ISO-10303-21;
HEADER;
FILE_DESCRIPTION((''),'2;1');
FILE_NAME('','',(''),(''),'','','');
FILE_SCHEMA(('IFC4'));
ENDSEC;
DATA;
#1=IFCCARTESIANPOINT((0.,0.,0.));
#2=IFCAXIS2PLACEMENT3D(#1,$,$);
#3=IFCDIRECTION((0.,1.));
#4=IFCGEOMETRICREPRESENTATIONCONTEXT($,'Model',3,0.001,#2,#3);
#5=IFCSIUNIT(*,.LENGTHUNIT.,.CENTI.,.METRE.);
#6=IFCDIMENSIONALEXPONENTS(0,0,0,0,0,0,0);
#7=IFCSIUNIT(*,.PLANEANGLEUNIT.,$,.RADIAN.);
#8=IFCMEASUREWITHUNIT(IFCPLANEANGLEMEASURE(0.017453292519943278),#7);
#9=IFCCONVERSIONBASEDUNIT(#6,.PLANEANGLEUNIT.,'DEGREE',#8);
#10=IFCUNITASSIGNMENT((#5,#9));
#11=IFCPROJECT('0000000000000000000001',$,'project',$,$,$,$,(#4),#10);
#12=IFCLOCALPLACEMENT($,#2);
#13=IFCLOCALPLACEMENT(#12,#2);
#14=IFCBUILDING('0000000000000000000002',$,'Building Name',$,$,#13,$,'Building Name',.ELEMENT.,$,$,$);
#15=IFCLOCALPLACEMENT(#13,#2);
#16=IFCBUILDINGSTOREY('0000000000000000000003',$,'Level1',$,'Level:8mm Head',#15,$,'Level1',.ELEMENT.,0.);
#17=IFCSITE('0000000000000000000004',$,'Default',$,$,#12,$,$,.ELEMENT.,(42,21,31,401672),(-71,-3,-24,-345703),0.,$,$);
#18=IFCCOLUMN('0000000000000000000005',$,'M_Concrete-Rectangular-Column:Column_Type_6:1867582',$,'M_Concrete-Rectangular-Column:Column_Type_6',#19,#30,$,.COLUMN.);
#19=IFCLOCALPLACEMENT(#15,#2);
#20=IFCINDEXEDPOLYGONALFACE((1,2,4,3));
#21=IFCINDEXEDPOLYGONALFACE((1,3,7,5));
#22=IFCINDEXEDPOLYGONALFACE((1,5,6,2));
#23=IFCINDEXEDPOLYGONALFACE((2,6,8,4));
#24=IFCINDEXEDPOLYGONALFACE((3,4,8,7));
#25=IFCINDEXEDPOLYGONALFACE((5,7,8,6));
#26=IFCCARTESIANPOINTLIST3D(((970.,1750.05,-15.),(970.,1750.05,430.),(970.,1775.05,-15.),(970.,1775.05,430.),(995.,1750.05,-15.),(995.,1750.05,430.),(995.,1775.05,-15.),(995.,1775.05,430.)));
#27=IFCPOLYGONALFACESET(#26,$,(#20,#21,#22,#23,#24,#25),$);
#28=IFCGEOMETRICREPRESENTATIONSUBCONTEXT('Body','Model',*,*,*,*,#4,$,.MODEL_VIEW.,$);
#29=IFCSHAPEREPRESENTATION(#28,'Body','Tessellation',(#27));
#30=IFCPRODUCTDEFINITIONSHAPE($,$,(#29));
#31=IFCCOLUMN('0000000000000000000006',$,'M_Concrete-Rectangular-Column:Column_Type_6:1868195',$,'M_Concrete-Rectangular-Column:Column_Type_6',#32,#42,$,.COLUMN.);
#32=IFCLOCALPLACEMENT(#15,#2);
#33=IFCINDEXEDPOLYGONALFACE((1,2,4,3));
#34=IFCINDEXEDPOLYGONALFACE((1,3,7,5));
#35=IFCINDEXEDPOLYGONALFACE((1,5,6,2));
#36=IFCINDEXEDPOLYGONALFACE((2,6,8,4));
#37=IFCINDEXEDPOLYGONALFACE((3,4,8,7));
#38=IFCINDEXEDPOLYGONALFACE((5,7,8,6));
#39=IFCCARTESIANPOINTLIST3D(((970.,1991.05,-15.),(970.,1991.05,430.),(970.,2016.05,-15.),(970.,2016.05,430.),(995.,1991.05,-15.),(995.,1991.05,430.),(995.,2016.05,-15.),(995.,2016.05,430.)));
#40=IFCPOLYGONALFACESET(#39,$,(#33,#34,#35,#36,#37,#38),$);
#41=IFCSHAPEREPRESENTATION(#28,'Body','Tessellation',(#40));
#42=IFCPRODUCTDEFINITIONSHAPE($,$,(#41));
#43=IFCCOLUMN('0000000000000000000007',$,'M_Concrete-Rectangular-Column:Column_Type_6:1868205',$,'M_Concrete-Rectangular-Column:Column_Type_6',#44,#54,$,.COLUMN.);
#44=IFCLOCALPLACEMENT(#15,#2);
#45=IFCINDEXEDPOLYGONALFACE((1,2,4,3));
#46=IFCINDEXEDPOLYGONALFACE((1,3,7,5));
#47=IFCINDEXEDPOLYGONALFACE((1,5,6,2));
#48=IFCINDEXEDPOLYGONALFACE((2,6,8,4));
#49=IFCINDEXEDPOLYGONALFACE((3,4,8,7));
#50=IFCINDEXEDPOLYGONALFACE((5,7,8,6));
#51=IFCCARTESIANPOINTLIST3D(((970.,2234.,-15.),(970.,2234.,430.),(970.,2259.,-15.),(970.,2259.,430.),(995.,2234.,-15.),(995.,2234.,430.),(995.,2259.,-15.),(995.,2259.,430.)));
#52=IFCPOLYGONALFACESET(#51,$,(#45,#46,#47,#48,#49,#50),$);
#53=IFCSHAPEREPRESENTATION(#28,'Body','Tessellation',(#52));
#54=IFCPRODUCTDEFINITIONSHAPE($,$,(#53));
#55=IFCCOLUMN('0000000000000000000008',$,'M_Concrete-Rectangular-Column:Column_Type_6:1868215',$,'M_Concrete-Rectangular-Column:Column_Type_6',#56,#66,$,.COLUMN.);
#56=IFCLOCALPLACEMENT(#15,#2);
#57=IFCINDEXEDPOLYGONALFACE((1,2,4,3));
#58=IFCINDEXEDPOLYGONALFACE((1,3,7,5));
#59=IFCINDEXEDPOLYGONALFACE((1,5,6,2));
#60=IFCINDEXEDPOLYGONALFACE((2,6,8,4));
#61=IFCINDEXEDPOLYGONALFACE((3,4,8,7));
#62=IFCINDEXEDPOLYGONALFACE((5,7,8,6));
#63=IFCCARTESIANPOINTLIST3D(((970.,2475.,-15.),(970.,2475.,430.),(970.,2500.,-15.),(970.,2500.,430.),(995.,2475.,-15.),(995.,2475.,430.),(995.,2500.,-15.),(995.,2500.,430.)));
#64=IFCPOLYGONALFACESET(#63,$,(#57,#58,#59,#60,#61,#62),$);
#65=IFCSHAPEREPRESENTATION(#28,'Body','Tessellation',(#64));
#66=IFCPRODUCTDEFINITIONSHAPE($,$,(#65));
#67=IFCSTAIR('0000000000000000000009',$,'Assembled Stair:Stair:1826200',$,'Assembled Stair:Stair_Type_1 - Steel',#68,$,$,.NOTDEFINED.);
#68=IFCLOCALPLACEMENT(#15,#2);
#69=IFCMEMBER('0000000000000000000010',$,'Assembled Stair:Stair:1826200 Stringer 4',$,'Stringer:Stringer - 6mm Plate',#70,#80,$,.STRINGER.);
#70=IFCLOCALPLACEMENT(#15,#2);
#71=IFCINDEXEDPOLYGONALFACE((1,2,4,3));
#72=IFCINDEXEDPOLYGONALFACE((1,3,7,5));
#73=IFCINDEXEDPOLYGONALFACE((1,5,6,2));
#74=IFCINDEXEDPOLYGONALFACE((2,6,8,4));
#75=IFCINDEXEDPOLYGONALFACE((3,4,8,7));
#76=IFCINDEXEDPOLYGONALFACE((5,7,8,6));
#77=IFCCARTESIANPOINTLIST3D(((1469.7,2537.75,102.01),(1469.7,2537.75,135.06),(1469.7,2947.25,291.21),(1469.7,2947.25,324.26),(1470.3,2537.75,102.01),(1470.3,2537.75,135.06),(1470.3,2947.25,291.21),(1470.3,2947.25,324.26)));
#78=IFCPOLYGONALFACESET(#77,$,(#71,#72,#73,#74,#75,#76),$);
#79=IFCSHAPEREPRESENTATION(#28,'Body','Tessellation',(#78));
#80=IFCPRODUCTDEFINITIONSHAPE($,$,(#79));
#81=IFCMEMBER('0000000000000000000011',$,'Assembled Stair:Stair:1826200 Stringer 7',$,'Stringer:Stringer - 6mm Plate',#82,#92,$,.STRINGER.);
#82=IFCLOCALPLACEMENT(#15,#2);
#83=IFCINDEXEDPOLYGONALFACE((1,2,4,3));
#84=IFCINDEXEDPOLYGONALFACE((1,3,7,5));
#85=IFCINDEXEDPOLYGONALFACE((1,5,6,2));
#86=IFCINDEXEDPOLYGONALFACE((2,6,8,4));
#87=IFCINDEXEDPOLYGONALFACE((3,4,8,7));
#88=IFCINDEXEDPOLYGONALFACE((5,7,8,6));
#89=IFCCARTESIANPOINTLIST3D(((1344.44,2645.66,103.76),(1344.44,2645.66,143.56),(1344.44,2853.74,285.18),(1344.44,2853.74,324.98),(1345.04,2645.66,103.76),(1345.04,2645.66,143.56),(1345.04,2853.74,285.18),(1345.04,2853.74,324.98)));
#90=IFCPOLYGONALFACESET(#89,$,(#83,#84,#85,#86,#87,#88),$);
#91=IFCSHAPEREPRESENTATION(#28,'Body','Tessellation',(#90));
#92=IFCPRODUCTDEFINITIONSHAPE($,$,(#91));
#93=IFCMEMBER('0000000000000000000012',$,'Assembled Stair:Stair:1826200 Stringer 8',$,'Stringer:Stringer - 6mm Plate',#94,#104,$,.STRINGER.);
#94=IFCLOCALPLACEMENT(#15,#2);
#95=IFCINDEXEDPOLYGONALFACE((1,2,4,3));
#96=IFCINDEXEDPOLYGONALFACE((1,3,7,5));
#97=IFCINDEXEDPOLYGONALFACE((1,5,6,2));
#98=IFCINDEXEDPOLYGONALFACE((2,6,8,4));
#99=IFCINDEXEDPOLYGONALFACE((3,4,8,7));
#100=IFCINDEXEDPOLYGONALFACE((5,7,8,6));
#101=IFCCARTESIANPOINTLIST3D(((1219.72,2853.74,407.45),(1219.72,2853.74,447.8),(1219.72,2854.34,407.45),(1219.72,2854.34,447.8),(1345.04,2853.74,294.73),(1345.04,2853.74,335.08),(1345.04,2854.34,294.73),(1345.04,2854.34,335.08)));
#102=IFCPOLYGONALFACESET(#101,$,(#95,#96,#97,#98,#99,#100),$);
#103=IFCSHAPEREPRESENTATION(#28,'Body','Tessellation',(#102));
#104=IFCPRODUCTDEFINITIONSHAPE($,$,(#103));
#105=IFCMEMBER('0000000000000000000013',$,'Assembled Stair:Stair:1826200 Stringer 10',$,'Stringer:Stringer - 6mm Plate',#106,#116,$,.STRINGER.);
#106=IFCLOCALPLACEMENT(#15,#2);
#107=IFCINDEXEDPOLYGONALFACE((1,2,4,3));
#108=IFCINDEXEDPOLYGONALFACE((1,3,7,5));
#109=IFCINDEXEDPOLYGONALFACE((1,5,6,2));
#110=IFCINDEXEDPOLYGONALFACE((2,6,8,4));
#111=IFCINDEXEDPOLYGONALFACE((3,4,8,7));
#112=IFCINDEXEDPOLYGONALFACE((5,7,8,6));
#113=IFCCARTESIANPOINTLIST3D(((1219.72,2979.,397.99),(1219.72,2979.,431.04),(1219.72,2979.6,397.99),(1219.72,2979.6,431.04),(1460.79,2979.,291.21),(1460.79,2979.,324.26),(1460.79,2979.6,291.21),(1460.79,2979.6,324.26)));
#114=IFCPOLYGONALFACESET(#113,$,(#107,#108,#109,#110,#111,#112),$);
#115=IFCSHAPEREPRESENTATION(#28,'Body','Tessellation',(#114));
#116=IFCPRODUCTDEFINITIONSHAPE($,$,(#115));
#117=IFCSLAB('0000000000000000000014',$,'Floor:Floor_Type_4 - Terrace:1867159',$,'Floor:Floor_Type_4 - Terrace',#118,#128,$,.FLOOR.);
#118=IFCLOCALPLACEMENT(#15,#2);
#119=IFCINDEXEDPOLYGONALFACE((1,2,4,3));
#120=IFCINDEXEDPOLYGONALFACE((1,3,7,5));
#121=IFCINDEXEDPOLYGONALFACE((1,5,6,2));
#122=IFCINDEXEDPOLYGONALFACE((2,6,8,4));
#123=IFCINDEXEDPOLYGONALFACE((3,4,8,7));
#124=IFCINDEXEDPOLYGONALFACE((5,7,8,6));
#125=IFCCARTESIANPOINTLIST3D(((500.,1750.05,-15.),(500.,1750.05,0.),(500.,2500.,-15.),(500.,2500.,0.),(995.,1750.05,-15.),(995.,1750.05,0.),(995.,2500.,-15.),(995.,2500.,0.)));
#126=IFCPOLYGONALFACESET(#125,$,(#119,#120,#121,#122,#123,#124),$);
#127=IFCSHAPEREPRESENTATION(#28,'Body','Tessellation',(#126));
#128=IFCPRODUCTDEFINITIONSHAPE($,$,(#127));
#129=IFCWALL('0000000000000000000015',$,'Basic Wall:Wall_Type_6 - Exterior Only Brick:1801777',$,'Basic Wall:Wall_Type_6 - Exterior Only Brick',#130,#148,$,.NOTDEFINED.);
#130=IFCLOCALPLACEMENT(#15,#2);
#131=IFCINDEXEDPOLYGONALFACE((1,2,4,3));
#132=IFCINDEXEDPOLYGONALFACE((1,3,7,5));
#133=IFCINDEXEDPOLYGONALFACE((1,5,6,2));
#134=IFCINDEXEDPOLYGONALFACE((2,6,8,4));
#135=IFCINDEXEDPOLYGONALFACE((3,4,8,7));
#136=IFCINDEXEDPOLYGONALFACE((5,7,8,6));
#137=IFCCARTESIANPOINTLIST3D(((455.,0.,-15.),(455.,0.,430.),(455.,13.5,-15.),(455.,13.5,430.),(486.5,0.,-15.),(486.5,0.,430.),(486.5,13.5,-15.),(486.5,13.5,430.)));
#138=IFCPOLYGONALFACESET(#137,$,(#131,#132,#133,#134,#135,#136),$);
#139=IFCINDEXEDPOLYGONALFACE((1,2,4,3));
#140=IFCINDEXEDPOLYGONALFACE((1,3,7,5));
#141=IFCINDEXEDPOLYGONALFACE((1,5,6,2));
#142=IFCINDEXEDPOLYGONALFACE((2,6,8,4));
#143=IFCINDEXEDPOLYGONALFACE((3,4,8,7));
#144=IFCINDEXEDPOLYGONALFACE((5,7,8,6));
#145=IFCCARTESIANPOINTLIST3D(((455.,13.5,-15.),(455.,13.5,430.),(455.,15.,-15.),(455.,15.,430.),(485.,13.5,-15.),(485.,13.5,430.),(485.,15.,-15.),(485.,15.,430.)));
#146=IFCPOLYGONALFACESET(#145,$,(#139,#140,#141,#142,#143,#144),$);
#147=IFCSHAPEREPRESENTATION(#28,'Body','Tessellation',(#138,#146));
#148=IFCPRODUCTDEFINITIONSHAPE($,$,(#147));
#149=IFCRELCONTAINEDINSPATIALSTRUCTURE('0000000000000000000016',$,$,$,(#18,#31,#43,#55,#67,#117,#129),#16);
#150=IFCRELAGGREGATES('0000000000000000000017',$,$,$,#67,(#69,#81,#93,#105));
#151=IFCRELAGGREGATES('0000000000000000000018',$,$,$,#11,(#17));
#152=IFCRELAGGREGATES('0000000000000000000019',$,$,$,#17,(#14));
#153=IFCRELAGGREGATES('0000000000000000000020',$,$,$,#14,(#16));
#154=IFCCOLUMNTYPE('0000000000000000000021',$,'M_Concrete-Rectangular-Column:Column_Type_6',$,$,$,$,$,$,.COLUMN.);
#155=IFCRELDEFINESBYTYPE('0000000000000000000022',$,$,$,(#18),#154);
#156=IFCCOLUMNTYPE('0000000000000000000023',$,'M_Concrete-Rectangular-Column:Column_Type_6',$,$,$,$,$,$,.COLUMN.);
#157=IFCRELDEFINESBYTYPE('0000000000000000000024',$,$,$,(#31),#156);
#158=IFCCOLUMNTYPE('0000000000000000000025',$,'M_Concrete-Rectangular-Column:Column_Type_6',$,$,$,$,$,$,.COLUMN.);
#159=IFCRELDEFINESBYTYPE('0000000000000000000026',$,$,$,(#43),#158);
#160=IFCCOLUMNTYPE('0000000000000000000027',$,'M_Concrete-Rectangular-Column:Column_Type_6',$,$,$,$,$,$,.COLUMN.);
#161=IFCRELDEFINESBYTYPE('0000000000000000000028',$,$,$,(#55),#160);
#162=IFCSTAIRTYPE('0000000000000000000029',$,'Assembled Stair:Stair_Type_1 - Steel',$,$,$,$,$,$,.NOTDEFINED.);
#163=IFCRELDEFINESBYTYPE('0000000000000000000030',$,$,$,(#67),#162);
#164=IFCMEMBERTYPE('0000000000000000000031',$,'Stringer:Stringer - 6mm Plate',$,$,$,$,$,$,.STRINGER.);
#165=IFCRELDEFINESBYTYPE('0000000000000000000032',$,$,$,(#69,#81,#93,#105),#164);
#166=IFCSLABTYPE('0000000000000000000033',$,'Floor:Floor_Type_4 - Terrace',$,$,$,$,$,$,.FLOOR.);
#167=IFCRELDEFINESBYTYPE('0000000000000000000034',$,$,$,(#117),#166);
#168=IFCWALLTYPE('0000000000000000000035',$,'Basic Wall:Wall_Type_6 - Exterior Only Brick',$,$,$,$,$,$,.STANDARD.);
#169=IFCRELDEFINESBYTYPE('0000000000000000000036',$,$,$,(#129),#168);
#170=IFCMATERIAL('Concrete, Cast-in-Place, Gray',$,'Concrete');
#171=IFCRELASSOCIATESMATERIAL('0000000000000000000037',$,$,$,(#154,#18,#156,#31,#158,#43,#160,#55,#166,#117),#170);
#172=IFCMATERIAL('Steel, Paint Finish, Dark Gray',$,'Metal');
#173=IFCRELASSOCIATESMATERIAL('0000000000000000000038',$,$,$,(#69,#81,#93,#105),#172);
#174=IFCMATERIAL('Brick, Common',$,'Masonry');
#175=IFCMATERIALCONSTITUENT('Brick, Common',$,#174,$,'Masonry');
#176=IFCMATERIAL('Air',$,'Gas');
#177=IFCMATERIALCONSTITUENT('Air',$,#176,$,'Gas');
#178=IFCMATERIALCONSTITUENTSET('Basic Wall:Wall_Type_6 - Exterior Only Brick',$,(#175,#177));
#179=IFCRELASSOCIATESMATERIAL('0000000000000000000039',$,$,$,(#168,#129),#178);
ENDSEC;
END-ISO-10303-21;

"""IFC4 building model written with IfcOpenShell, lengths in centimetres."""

from ifc_helpers import new_model, entity, si_unit, converted_unit, direction, frame, origin, place, context, subcontext, project, spatial, indexed_curve, outline, extrude, source, transform, mapped, material, constituent, constituent_set, type_object, type_shapes, element, aggregate, save


model = new_model("IFC4")

# Units and contexts
model_context = context("Model", 3, precision=0.001, world=origin(), true_north=direction((0.0, 1.0)))
body_context = subcontext(model_context, "Body", "Model", "MODEL_VIEW")
ifc_project = project(units=[si_unit("LENGTHUNIT", "METRE", prefix="CENTI"), converted_unit("PLANEANGLEUNIT", "DEGREE", entity("IfcPlaneAngleMeasure", 0.017453292519943278), si_unit("PLANEANGLEUNIT", "RADIAN"), dimensions=[0, 0, 0, 0, 0, 0, 0])], contexts=[model_context])

# Site, building, storey
site_placement = place(None, origin())
site = spatial("IfcSite", under=ifc_project, at=site_placement, Name="Default", CompositionType="ELEMENT", RefLatitude=(42, 21, 31, 401672), RefLongitude=(-71, -3, -24, -345703), RefElevation=0.0)
building_placement = place(site_placement, origin())
building = spatial("IfcBuilding", under=site, at=building_placement, Name="Building Name", LongName="Building Name", CompositionType="ELEMENT")
storey_placement = place(building_placement, origin())
storey = spatial("IfcBuildingStorey", under=building, at=storey_placement, Name="Level1", ObjectType="Level:8mm Head", LongName="Level1", CompositionType="ELEMENT", Elevation=0.0)

# Columns
ifc_material_1 = material(Name="Concrete, Cast-in-Place, Gray", Category="Concrete")
column_type_1 = type_object("IfcColumnType", Name="M_Concrete-Rectangular-Column:Column_Type_6", PredefinedType="COLUMN", material=ifc_material_1)
shared_shape_1 = source(origin(), body_context, "Body", "SweptSolid", [
    extrude(outline(indexed_curve([(-12.5, -12.5), (12.5, -12.5), (12.5, 12.5), (-12.5, 12.5), (-12.5, -12.5)], self_intersect=False)), frame((982.5, 1762.55, -15.0), z_axis=(0.0, 0.0, 1.0), x_axis=(0.0, -1.0, 0.0)), (0.0, 0.0, 1.0), 445.0),
])
type_shapes(column_type_1, [shared_shape_1])
column_1_placement = place(storey_placement, origin())
element("IfcColumn", 1, at=column_1_placement, inside=storey, type_object=column_type_1, material=ifc_material_1, Name="M_Concrete-Rectangular-Column:Column_Type_6:1867582", ObjectType="M_Concrete-Rectangular-Column:Column_Type_6", PredefinedType="COLUMN", context=body_context, shape_type="MappedRepresentation", body=[
    mapped(shared_shape_1, transform((0.0, 0.0, 0.0), scale=1.0)),
])
column_type_2 = type_object("IfcColumnType", Name="M_Concrete-Rectangular-Column:Column_Type_6", PredefinedType="COLUMN", material=ifc_material_1)
shared_shape_2 = source(origin(), body_context, "Body", "SweptSolid", [
    extrude(outline(indexed_curve([(-12.5, -12.5), (12.5, -12.5), (12.5, 12.5), (-12.5, 12.5), (-12.5, -12.5)], self_intersect=False)), frame((982.5, 2003.55, -15.0), z_axis=(0.0, 0.0, 1.0), x_axis=(0.0, -1.0, 0.0)), (0.0, 0.0, 1.0), 445.0),
])
type_shapes(column_type_2, [shared_shape_2])
column_2_placement = place(storey_placement, origin())
element("IfcColumn", 2, at=column_2_placement, inside=storey, type_object=column_type_2, material=ifc_material_1, Name="M_Concrete-Rectangular-Column:Column_Type_6:1868195", ObjectType="M_Concrete-Rectangular-Column:Column_Type_6", PredefinedType="COLUMN", context=body_context, shape_type="MappedRepresentation", body=[
    mapped(shared_shape_2, transform((0.0, 0.0, 0.0), scale=1.0)),
])
column_type_3 = type_object("IfcColumnType", Name="M_Concrete-Rectangular-Column:Column_Type_6", PredefinedType="COLUMN", material=ifc_material_1)
shared_shape_3 = source(origin(), body_context, "Body", "SweptSolid", [
    extrude(outline(indexed_curve([(-12.5, -12.5), (12.5, -12.5), (12.5, 12.5), (-12.5, 12.5), (-12.5, -12.5)], self_intersect=False)), frame((982.5, 2246.5, -15.0), z_axis=(0.0, 0.0, 1.0), x_axis=(0.0, -1.0, 0.0)), (0.0, 0.0, 1.0), 445.0),
])
type_shapes(column_type_3, [shared_shape_3])
column_3_placement = place(storey_placement, origin())
element("IfcColumn", 3, at=column_3_placement, inside=storey, type_object=column_type_3, material=ifc_material_1, Name="M_Concrete-Rectangular-Column:Column_Type_6:1868205", ObjectType="M_Concrete-Rectangular-Column:Column_Type_6", PredefinedType="COLUMN", context=body_context, shape_type="MappedRepresentation", body=[
    mapped(shared_shape_3, transform((0.0, 0.0, 0.0), scale=1.0)),
])
column_type_4 = type_object("IfcColumnType", Name="M_Concrete-Rectangular-Column:Column_Type_6", PredefinedType="COLUMN", material=ifc_material_1)
shared_shape_4 = source(origin(), body_context, "Body", "SweptSolid", [
    extrude(outline(indexed_curve([(-12.5, -12.5), (12.5, -12.5), (12.5, 12.5), (-12.5, 12.5), (-12.5, -12.5)], self_intersect=False)), frame((982.5, 2487.5, -15.0), z_axis=(0.0, 0.0, 1.0), x_axis=(0.0, -1.0, 0.0)), (0.0, 0.0, 1.0), 445.0),
])
type_shapes(column_type_4, [shared_shape_4])
column_4_placement = place(storey_placement, origin())
element("IfcColumn", 4, at=column_4_placement, inside=storey, type_object=column_type_4, material=ifc_material_1, Name="M_Concrete-Rectangular-Column:Column_Type_6:1868215", ObjectType="M_Concrete-Rectangular-Column:Column_Type_6", PredefinedType="COLUMN", context=body_context, shape_type="MappedRepresentation", body=[
    mapped(shared_shape_4, transform((0.0, 0.0, 0.0), scale=1.0)),
])

# Stair, members
stair_type_1 = type_object("IfcStairType", Name="Assembled Stair:Stair_Type_1 - Steel", PredefinedType="NOTDEFINED")
stair_1_placement = place(storey_placement, origin())
stair_1 = element("IfcStair", 5, at=stair_1_placement, inside=storey, type_object=stair_type_1, Name="Assembled Stair:Stair:1826200", ObjectType="Assembled Stair:Stair_Type_1 - Steel", PredefinedType="NOTDEFINED")
ifc_material_2 = material(Name="Steel, Paint Finish, Dark Gray", Category="Metal")
member_type = type_object("IfcMemberType", Name="Stringer:Stringer - 6mm Plate", PredefinedType="STRINGER")
member_1_placement = place(stair_1_placement, origin())
member_1 = element("IfcMember", 6, at=member_1_placement, type_object=member_type, material=ifc_material_2, Name="Assembled Stair:Stair:1826200 Stringer 4", ObjectType="Stringer:Stringer - 6mm Plate", PredefinedType="STRINGER", context=body_context, shape_type="SweptSolid", body=[
    extrude(outline(indexed_curve([(-232.48, -15.0), (218.62, -15.0), (232.48, 15.0), (-218.62, 15.0), (-232.48, -15.0)], self_intersect=False)), frame((1469.7, 2742.5, 213.14), z_axis=(1.0, 0.0, 0.0), x_axis=(0.0, 0.907791, 0.419423)), (0.0, 0.0, 1.0), 0.6),
])
member_2_placement = place(stair_1_placement, origin())
member_2 = element("IfcMember", 7, at=member_2_placement, type_object=member_type, material=ifc_material_2, Name="Assembled Stair:Stair:1826200 Stringer 7", ObjectType="Stringer:Stringer - 6mm Plate", PredefinedType="STRINGER", context=body_context, shape_type="SweptSolid", body=[
    extrude(outline(indexed_curve([(-151.11, -15.0), (124.95, -15.0), (151.11, 15.0), (-124.95, 15.0), (-151.11, -15.0)], self_intersect=False)), frame((1344.44, 2749.7, 214.37), z_axis=(1.0, 0.0, 0.0), x_axis=(0.0, 0.753738, 0.657175)), (0.0, 0.0, 1.0), 0.6),
])
member_3_placement = place(stair_1_placement, origin())
member_3 = element("IfcMember", 8, at=member_3_placement, type_object=member_type, material=ifc_material_2, Name="Assembled Stair:Stair:1826200 Stringer 8", ObjectType="Stringer:Stringer - 6mm Plate", PredefinedType="STRINGER", context=body_context, shape_type="SweptSolid", body=[
    extrude(outline(indexed_curve([(-97.77, -15.0), (70.78, -15.0), (97.77, 15.0), (-70.78, 15.0), (-97.77, -15.0)], self_intersect=False)), frame((1282.38, 2853.74, 371.27), z_axis=(0.0, 1.0, 0.0), x_axis=(-0.7435, 0.0, 0.668736)), (0.0, 0.0, 1.0), 0.6),
])
member_4_placement = place(stair_1_placement, origin())
member_4 = element("IfcMember", 9, at=member_4_placement, type_object=member_type, material=ifc_material_2, Name="Assembled Stair:Stair:1826200 Stringer 10", ObjectType="Stringer:Stringer - 6mm Plate", PredefinedType="STRINGER", context=body_context, shape_type="SweptSolid", body=[
    extrude(outline(indexed_curve([(-138.52, -15.11), (125.14, -15.11), (138.52, 15.11), (-125.14, 15.11), (-138.52, -15.11)], self_intersect=False)), frame((1340.26, 2979.0, 361.13), z_axis=(0.0, 1.0, 0.0), x_axis=(-0.914317, 0.0, 0.405)), (0.0, 0.0, 1.0), 0.6),
])
aggregate(stair_1, [member_1, member_2, member_3, member_4])

# Slab
slab_type = type_object("IfcSlabType", Name="Floor:Floor_Type_4 - Terrace", PredefinedType="FLOOR", material=ifc_material_1)
slab_placement = place(storey_placement, origin())
element("IfcSlab", 10, at=slab_placement, inside=storey, type_object=slab_type, material=ifc_material_1, Name="Floor:Floor_Type_4 - Terrace:1867159", ObjectType="Floor:Floor_Type_4 - Terrace", PredefinedType="FLOOR", context=body_context, shape_type="SweptSolid", body=[
    extrude(outline(indexed_curve([(-374.98, -247.5), (374.98, -247.5), (374.98, 247.5), (-374.98, 247.5), (-374.98, -247.5)], self_intersect=False)), frame((747.5, 2125.02, 0.0), z_axis=(0.0, 0.0, -1.0), x_axis=(0.0, 1.0, 0.0)), (0.0, 0.0, 1.0), 15.0),
])

# Shared definitions
ifc_material_3 = material(Name="Brick, Common", Category="Masonry")
ifc_material_4 = material(Name="Air", Category="Gas")

# Wall
ifc_constituent_1 = constituent(ifc_material_3, Name="Brick, Common", Category="Masonry")
ifc_constituent_2 = constituent(ifc_material_4, Name="Air", Category="Gas")
ifc_constituent_set_1 = constituent_set(constituents=[ifc_constituent_1, ifc_constituent_2], Name="Basic Wall:Wall_Type_6 - Exterior Only Brick")
wall_type_1 = type_object("IfcWallType", Name="Basic Wall:Wall_Type_6 - Exterior Only Brick", PredefinedType="STANDARD", material=ifc_constituent_set_1)
wall_1_placement = place(storey_placement, frame((485.0, 7.5, -15.0), z_axis=(0.0, 0.0, 1.0), x_axis=(-1.0, 0.0, 0.0)))
element("IfcWall", 11, at=wall_1_placement, inside=storey, type_object=wall_type_1, material=ifc_constituent_set_1, Name="Basic Wall:Wall_Type_6 - Exterior Only Brick:1801777", ObjectType="Basic Wall:Wall_Type_6 - Exterior Only Brick", PredefinedType="NOTDEFINED", context=body_context, shape_type="SweptSolid", body=[
    extrude(outline(indexed_curve([(-6.75, -15.75), (6.75, -15.75), (6.75, 15.75), (-6.75, 15.75), (-6.75, -15.75)], self_intersect=False)), frame((14.25, 0.75, 0.0), z_axis=(0.0, 0.0, 1.0), x_axis=(0.0, -1.0, 0.0)), (0.0, 0.0, 1.0), 445.0),
    extrude(outline(indexed_curve([(-0.75, -15.0), (0.75, -15.0), (0.75, 15.0), (-0.75, 15.0), (-0.75, -15.0)], self_intersect=False)), frame((15.0, -6.75, 0.0), z_axis=(0.0, 0.0, 1.0), x_axis=(0.0, 1.0, 0.0)), (0.0, 0.0, 1.0), 445.0),
])

save(model, "model.ifc")
